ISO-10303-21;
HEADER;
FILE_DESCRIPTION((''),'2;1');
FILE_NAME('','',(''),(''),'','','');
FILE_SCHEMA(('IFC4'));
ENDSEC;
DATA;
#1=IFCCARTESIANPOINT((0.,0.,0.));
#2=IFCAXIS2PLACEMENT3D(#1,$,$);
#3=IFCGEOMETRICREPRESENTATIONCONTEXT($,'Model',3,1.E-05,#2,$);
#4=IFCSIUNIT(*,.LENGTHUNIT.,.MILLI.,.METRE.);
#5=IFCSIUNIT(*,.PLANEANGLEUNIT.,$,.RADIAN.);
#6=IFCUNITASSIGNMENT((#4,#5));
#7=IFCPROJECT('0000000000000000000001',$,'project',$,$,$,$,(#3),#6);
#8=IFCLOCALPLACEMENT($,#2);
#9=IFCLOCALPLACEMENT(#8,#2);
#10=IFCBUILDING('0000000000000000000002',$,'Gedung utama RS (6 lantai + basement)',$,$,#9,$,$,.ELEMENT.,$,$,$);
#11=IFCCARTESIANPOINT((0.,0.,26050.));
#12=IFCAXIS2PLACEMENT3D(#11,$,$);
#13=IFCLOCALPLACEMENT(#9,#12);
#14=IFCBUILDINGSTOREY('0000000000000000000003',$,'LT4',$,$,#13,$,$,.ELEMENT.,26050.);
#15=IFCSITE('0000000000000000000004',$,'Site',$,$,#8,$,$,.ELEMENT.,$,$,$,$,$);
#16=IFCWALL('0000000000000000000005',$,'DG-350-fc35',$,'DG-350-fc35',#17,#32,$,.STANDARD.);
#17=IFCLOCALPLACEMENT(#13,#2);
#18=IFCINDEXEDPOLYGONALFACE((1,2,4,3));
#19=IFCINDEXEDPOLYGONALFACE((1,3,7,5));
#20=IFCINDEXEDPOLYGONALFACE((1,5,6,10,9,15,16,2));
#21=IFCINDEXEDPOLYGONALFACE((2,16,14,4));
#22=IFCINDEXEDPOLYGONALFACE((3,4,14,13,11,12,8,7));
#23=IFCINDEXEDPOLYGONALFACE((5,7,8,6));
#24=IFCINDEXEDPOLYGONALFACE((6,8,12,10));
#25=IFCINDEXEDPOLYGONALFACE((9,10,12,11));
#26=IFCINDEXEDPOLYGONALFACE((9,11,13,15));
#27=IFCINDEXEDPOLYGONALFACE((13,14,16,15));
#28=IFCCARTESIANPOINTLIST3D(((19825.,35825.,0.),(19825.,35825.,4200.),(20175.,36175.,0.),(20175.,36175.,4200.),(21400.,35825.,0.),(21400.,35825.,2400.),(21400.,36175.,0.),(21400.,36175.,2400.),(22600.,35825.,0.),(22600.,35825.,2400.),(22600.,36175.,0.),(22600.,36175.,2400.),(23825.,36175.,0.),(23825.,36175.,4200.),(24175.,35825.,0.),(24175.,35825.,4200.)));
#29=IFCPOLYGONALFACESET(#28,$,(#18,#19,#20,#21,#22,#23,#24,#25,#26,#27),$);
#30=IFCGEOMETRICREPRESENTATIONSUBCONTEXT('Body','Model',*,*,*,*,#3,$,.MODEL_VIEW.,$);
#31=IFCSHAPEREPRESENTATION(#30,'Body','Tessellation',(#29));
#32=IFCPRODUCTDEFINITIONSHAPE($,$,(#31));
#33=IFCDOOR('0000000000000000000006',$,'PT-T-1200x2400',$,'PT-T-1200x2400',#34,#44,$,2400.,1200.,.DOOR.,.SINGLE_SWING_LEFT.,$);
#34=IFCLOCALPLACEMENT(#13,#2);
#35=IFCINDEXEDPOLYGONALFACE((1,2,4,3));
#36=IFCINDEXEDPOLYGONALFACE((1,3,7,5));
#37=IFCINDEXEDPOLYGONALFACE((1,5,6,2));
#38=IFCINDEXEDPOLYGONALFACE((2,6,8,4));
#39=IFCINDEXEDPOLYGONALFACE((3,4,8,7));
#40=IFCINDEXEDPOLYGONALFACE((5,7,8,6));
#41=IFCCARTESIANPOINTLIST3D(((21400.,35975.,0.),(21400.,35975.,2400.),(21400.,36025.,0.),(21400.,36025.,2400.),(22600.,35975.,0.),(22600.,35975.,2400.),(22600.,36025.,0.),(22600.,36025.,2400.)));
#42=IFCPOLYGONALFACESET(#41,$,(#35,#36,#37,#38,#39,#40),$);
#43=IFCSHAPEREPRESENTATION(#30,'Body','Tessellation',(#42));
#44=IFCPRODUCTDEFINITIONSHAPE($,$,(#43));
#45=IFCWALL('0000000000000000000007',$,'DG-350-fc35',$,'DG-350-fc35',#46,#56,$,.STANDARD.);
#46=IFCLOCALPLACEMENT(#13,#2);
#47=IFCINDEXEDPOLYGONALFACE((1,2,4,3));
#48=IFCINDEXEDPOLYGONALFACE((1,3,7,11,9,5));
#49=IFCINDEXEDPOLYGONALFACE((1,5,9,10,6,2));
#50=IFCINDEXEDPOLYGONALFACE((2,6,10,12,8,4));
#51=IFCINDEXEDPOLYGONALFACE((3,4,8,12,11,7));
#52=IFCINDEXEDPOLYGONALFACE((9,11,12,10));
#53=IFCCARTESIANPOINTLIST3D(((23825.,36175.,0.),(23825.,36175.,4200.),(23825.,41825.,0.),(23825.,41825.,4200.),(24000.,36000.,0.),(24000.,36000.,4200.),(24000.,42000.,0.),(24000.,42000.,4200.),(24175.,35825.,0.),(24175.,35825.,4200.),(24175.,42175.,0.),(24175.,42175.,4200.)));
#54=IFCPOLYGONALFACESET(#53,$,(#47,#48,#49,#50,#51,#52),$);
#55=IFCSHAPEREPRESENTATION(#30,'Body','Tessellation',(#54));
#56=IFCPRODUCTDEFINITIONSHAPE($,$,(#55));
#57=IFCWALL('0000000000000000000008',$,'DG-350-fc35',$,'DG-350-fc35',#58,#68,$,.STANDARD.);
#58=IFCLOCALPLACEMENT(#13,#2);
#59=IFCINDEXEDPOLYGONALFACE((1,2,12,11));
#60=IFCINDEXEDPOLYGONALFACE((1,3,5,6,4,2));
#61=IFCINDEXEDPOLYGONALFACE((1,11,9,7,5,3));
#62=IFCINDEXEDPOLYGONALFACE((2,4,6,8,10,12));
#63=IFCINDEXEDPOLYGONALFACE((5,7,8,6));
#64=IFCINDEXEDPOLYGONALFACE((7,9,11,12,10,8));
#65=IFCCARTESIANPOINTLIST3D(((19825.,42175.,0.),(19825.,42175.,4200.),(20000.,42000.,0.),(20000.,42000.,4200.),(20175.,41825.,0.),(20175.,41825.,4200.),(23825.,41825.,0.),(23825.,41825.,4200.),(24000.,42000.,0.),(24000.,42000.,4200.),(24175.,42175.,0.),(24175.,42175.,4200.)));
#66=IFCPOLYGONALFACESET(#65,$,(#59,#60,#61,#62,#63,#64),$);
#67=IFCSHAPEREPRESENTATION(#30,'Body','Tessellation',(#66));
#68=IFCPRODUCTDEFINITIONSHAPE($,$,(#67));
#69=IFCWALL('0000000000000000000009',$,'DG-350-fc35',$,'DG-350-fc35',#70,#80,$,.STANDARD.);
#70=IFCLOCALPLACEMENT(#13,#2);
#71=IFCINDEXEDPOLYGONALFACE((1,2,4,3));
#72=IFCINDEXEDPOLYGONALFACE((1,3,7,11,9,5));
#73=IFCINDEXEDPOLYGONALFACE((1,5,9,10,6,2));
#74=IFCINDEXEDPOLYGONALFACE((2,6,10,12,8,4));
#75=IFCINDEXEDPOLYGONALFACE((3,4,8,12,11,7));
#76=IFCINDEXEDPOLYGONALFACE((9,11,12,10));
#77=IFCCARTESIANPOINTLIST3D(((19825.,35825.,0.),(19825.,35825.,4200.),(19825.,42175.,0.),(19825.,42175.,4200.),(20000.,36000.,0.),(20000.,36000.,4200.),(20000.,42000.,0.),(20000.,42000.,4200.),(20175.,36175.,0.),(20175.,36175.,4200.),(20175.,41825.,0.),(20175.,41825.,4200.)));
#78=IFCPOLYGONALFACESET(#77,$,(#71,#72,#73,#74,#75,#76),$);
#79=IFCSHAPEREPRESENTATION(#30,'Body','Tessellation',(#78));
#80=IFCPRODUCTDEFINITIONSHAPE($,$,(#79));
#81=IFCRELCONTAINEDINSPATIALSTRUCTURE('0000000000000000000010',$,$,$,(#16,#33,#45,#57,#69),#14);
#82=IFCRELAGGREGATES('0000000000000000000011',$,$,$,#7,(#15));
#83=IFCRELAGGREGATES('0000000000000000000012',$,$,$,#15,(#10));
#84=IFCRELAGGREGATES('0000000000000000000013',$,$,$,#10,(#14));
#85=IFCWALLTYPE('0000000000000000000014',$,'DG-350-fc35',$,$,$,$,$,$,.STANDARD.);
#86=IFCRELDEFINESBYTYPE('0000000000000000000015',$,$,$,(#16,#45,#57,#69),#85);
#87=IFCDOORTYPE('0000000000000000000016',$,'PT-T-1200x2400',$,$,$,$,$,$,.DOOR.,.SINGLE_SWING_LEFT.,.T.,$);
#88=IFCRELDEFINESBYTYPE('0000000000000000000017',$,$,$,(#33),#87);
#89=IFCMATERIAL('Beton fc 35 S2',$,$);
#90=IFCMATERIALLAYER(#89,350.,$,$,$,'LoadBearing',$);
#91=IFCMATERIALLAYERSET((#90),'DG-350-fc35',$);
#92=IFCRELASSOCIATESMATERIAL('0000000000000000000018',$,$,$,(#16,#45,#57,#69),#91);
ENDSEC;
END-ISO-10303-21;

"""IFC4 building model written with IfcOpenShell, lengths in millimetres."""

from ifc_helpers import new_model, si_unit, frame, frame_2d, origin, place, context, subcontext, project, spatial, polyline, rectangle, outline, extrude, material, layer, layer_set, layer_usage, type_object, element, fill, save


model = new_model("IFC4")

# Units and contexts
model_context = context("Model", 3, precision=1e-05, world=origin())
body_context = subcontext(model_context, "Body", "Model", "MODEL_VIEW")
ifc_project = project(units=[si_unit("LENGTHUNIT", "METRE", prefix="MILLI"), si_unit("PLANEANGLEUNIT", "RADIAN")], contexts=[model_context])

# Site, building, storey
site_placement = place(None, origin())
site = spatial("IfcSite", under=ifc_project, at=site_placement, Name="Site", CompositionType="ELEMENT")
building_placement = place(site_placement, origin())
building = spatial("IfcBuilding", under=site, at=building_placement, Name="Gedung utama RS (6 lantai + basement)", CompositionType="ELEMENT")
storey_placement = place(building_placement, frame((0.0, 0.0, 26050.0)))
storey = spatial("IfcBuildingStorey", under=building, at=storey_placement, Name="LT4", CompositionType="ELEMENT", Elevation=26050.0)

# Wall, opening, door
ifc_material_1 = material(Name="Beton fc 35 S2")
ifc_layer = layer(ifc_material_1, 350.0, Category="LoadBearing")
ifc_layer_set = layer_set([ifc_layer], Name="DG-350-fc35")
ifc_layer_usage = layer_usage(ifc_layer_set, "AXIS2", "NEGATIVE", 175.0)
wall_type = type_object("IfcWallType", Name="DG-350-fc35", PredefinedType="STANDARD")
wall_1_placement = place(storey_placement, frame((20000.0, 36000.0, 0.0), z_axis=(0.0, 0.0, 1.0), x_axis=(1.0, 0.0, 0.0)))
wall_1 = element("IfcWall", 1, at=wall_1_placement, inside=storey, type_object=wall_type, material=ifc_layer_usage, Name="DG-350-fc35", ObjectType="DG-350-fc35", PredefinedType="STANDARD", context=body_context, shape_type="SweptSolid", body=[
    extrude(outline(polyline([(-175.0, -175.0), (0.0, 0.0), (175.0, 175.0), (3825.0, 175.0), (4000.0, 0.0), (4175.0, -175.0), (-175.0, -175.0)])), origin(), (0.0, 0.0, 1.0), 4200.0),
])
opening_placement = place(wall_1_placement, frame((1400.0, 0.0, 0.0), z_axis=(0.0, 0.0, 1.0), x_axis=(1.0, 0.0, 0.0)))
opening = element("IfcOpeningElement", 2, at=opening_placement, cuts=wall_1, PredefinedType="OPENING", context=body_context, shape_type="SweptSolid", body=[
    extrude(rectangle(XDim=1200.0, YDim=370.0, at=frame_2d((600.0, 0.0))), origin(), (0.0, 0.0, 1.0), 2400.0),
])
door_type = type_object("IfcDoorType", Name="PT-T-1200x2400", OperationType="SINGLE_SWING_LEFT", ParameterTakesPrecedence=True, PredefinedType="DOOR")
door_placement = place(opening_placement, origin())
door = element("IfcDoor", 3, at=door_placement, inside=storey, type_object=door_type, Name="PT-T-1200x2400", ObjectType="PT-T-1200x2400", OperationType="SINGLE_SWING_LEFT", OverallHeight=2400.0, OverallWidth=1200.0, PredefinedType="DOOR", context=body_context, shape_type="SweptSolid", body=[
    extrude(rectangle(XDim=1200.0, YDim=50.0, at=frame_2d((600.0, 0.0))), origin(), (0.0, 0.0, 1.0), 2400.0),
])
fill(opening, door)

# Walls
wall_2_placement = place(storey_placement, frame((24000.0, 36000.0, 0.0), z_axis=(0.0, 0.0, 1.0), x_axis=(0.0, 1.0, 0.0)))
element("IfcWall", 4, at=wall_2_placement, inside=storey, type_object=wall_type, material=ifc_layer_usage, Name="DG-350-fc35", ObjectType="DG-350-fc35", PredefinedType="STANDARD", context=body_context, shape_type="SweptSolid", body=[
    extrude(outline(polyline([(-175.0, -175.0), (0.0, 0.0), (175.0, 175.0), (5825.0, 175.0), (6000.0, 0.0), (6175.0, -175.0), (-175.0, -175.0)])), origin(), (0.0, 0.0, 1.0), 4200.0),
])
wall_3_placement = place(storey_placement, frame((24000.0, 42000.0, 0.0), z_axis=(0.0, 0.0, 1.0), x_axis=(-1.0, 0.0, 0.0)))
element("IfcWall", 5, at=wall_3_placement, inside=storey, type_object=wall_type, material=ifc_layer_usage, Name="DG-350-fc35", ObjectType="DG-350-fc35", PredefinedType="STANDARD", context=body_context, shape_type="SweptSolid", body=[
    extrude(outline(polyline([(-175.0, -175.0), (0.0, 0.0), (175.0, 175.0), (3825.0, 175.0), (4000.0, 0.0), (4175.0, -175.0), (-175.0, -175.0)])), origin(), (0.0, 0.0, 1.0), 4200.0),
])
wall_4_placement = place(storey_placement, frame((20000.0, 42000.0, 0.0), z_axis=(0.0, 0.0, 1.0), x_axis=(0.0, -1.0, 0.0)))
element("IfcWall", 6, at=wall_4_placement, inside=storey, type_object=wall_type, material=ifc_layer_usage, Name="DG-350-fc35", ObjectType="DG-350-fc35", PredefinedType="STANDARD", context=body_context, shape_type="SweptSolid", body=[
    extrude(outline(polyline([(-175.0, -175.0), (0.0, 0.0), (175.0, 175.0), (5825.0, 175.0), (6000.0, 0.0), (6175.0, -175.0), (-175.0, -175.0)])), origin(), (0.0, 0.0, 1.0), 4200.0),
])

save(model, "model.ifc")
